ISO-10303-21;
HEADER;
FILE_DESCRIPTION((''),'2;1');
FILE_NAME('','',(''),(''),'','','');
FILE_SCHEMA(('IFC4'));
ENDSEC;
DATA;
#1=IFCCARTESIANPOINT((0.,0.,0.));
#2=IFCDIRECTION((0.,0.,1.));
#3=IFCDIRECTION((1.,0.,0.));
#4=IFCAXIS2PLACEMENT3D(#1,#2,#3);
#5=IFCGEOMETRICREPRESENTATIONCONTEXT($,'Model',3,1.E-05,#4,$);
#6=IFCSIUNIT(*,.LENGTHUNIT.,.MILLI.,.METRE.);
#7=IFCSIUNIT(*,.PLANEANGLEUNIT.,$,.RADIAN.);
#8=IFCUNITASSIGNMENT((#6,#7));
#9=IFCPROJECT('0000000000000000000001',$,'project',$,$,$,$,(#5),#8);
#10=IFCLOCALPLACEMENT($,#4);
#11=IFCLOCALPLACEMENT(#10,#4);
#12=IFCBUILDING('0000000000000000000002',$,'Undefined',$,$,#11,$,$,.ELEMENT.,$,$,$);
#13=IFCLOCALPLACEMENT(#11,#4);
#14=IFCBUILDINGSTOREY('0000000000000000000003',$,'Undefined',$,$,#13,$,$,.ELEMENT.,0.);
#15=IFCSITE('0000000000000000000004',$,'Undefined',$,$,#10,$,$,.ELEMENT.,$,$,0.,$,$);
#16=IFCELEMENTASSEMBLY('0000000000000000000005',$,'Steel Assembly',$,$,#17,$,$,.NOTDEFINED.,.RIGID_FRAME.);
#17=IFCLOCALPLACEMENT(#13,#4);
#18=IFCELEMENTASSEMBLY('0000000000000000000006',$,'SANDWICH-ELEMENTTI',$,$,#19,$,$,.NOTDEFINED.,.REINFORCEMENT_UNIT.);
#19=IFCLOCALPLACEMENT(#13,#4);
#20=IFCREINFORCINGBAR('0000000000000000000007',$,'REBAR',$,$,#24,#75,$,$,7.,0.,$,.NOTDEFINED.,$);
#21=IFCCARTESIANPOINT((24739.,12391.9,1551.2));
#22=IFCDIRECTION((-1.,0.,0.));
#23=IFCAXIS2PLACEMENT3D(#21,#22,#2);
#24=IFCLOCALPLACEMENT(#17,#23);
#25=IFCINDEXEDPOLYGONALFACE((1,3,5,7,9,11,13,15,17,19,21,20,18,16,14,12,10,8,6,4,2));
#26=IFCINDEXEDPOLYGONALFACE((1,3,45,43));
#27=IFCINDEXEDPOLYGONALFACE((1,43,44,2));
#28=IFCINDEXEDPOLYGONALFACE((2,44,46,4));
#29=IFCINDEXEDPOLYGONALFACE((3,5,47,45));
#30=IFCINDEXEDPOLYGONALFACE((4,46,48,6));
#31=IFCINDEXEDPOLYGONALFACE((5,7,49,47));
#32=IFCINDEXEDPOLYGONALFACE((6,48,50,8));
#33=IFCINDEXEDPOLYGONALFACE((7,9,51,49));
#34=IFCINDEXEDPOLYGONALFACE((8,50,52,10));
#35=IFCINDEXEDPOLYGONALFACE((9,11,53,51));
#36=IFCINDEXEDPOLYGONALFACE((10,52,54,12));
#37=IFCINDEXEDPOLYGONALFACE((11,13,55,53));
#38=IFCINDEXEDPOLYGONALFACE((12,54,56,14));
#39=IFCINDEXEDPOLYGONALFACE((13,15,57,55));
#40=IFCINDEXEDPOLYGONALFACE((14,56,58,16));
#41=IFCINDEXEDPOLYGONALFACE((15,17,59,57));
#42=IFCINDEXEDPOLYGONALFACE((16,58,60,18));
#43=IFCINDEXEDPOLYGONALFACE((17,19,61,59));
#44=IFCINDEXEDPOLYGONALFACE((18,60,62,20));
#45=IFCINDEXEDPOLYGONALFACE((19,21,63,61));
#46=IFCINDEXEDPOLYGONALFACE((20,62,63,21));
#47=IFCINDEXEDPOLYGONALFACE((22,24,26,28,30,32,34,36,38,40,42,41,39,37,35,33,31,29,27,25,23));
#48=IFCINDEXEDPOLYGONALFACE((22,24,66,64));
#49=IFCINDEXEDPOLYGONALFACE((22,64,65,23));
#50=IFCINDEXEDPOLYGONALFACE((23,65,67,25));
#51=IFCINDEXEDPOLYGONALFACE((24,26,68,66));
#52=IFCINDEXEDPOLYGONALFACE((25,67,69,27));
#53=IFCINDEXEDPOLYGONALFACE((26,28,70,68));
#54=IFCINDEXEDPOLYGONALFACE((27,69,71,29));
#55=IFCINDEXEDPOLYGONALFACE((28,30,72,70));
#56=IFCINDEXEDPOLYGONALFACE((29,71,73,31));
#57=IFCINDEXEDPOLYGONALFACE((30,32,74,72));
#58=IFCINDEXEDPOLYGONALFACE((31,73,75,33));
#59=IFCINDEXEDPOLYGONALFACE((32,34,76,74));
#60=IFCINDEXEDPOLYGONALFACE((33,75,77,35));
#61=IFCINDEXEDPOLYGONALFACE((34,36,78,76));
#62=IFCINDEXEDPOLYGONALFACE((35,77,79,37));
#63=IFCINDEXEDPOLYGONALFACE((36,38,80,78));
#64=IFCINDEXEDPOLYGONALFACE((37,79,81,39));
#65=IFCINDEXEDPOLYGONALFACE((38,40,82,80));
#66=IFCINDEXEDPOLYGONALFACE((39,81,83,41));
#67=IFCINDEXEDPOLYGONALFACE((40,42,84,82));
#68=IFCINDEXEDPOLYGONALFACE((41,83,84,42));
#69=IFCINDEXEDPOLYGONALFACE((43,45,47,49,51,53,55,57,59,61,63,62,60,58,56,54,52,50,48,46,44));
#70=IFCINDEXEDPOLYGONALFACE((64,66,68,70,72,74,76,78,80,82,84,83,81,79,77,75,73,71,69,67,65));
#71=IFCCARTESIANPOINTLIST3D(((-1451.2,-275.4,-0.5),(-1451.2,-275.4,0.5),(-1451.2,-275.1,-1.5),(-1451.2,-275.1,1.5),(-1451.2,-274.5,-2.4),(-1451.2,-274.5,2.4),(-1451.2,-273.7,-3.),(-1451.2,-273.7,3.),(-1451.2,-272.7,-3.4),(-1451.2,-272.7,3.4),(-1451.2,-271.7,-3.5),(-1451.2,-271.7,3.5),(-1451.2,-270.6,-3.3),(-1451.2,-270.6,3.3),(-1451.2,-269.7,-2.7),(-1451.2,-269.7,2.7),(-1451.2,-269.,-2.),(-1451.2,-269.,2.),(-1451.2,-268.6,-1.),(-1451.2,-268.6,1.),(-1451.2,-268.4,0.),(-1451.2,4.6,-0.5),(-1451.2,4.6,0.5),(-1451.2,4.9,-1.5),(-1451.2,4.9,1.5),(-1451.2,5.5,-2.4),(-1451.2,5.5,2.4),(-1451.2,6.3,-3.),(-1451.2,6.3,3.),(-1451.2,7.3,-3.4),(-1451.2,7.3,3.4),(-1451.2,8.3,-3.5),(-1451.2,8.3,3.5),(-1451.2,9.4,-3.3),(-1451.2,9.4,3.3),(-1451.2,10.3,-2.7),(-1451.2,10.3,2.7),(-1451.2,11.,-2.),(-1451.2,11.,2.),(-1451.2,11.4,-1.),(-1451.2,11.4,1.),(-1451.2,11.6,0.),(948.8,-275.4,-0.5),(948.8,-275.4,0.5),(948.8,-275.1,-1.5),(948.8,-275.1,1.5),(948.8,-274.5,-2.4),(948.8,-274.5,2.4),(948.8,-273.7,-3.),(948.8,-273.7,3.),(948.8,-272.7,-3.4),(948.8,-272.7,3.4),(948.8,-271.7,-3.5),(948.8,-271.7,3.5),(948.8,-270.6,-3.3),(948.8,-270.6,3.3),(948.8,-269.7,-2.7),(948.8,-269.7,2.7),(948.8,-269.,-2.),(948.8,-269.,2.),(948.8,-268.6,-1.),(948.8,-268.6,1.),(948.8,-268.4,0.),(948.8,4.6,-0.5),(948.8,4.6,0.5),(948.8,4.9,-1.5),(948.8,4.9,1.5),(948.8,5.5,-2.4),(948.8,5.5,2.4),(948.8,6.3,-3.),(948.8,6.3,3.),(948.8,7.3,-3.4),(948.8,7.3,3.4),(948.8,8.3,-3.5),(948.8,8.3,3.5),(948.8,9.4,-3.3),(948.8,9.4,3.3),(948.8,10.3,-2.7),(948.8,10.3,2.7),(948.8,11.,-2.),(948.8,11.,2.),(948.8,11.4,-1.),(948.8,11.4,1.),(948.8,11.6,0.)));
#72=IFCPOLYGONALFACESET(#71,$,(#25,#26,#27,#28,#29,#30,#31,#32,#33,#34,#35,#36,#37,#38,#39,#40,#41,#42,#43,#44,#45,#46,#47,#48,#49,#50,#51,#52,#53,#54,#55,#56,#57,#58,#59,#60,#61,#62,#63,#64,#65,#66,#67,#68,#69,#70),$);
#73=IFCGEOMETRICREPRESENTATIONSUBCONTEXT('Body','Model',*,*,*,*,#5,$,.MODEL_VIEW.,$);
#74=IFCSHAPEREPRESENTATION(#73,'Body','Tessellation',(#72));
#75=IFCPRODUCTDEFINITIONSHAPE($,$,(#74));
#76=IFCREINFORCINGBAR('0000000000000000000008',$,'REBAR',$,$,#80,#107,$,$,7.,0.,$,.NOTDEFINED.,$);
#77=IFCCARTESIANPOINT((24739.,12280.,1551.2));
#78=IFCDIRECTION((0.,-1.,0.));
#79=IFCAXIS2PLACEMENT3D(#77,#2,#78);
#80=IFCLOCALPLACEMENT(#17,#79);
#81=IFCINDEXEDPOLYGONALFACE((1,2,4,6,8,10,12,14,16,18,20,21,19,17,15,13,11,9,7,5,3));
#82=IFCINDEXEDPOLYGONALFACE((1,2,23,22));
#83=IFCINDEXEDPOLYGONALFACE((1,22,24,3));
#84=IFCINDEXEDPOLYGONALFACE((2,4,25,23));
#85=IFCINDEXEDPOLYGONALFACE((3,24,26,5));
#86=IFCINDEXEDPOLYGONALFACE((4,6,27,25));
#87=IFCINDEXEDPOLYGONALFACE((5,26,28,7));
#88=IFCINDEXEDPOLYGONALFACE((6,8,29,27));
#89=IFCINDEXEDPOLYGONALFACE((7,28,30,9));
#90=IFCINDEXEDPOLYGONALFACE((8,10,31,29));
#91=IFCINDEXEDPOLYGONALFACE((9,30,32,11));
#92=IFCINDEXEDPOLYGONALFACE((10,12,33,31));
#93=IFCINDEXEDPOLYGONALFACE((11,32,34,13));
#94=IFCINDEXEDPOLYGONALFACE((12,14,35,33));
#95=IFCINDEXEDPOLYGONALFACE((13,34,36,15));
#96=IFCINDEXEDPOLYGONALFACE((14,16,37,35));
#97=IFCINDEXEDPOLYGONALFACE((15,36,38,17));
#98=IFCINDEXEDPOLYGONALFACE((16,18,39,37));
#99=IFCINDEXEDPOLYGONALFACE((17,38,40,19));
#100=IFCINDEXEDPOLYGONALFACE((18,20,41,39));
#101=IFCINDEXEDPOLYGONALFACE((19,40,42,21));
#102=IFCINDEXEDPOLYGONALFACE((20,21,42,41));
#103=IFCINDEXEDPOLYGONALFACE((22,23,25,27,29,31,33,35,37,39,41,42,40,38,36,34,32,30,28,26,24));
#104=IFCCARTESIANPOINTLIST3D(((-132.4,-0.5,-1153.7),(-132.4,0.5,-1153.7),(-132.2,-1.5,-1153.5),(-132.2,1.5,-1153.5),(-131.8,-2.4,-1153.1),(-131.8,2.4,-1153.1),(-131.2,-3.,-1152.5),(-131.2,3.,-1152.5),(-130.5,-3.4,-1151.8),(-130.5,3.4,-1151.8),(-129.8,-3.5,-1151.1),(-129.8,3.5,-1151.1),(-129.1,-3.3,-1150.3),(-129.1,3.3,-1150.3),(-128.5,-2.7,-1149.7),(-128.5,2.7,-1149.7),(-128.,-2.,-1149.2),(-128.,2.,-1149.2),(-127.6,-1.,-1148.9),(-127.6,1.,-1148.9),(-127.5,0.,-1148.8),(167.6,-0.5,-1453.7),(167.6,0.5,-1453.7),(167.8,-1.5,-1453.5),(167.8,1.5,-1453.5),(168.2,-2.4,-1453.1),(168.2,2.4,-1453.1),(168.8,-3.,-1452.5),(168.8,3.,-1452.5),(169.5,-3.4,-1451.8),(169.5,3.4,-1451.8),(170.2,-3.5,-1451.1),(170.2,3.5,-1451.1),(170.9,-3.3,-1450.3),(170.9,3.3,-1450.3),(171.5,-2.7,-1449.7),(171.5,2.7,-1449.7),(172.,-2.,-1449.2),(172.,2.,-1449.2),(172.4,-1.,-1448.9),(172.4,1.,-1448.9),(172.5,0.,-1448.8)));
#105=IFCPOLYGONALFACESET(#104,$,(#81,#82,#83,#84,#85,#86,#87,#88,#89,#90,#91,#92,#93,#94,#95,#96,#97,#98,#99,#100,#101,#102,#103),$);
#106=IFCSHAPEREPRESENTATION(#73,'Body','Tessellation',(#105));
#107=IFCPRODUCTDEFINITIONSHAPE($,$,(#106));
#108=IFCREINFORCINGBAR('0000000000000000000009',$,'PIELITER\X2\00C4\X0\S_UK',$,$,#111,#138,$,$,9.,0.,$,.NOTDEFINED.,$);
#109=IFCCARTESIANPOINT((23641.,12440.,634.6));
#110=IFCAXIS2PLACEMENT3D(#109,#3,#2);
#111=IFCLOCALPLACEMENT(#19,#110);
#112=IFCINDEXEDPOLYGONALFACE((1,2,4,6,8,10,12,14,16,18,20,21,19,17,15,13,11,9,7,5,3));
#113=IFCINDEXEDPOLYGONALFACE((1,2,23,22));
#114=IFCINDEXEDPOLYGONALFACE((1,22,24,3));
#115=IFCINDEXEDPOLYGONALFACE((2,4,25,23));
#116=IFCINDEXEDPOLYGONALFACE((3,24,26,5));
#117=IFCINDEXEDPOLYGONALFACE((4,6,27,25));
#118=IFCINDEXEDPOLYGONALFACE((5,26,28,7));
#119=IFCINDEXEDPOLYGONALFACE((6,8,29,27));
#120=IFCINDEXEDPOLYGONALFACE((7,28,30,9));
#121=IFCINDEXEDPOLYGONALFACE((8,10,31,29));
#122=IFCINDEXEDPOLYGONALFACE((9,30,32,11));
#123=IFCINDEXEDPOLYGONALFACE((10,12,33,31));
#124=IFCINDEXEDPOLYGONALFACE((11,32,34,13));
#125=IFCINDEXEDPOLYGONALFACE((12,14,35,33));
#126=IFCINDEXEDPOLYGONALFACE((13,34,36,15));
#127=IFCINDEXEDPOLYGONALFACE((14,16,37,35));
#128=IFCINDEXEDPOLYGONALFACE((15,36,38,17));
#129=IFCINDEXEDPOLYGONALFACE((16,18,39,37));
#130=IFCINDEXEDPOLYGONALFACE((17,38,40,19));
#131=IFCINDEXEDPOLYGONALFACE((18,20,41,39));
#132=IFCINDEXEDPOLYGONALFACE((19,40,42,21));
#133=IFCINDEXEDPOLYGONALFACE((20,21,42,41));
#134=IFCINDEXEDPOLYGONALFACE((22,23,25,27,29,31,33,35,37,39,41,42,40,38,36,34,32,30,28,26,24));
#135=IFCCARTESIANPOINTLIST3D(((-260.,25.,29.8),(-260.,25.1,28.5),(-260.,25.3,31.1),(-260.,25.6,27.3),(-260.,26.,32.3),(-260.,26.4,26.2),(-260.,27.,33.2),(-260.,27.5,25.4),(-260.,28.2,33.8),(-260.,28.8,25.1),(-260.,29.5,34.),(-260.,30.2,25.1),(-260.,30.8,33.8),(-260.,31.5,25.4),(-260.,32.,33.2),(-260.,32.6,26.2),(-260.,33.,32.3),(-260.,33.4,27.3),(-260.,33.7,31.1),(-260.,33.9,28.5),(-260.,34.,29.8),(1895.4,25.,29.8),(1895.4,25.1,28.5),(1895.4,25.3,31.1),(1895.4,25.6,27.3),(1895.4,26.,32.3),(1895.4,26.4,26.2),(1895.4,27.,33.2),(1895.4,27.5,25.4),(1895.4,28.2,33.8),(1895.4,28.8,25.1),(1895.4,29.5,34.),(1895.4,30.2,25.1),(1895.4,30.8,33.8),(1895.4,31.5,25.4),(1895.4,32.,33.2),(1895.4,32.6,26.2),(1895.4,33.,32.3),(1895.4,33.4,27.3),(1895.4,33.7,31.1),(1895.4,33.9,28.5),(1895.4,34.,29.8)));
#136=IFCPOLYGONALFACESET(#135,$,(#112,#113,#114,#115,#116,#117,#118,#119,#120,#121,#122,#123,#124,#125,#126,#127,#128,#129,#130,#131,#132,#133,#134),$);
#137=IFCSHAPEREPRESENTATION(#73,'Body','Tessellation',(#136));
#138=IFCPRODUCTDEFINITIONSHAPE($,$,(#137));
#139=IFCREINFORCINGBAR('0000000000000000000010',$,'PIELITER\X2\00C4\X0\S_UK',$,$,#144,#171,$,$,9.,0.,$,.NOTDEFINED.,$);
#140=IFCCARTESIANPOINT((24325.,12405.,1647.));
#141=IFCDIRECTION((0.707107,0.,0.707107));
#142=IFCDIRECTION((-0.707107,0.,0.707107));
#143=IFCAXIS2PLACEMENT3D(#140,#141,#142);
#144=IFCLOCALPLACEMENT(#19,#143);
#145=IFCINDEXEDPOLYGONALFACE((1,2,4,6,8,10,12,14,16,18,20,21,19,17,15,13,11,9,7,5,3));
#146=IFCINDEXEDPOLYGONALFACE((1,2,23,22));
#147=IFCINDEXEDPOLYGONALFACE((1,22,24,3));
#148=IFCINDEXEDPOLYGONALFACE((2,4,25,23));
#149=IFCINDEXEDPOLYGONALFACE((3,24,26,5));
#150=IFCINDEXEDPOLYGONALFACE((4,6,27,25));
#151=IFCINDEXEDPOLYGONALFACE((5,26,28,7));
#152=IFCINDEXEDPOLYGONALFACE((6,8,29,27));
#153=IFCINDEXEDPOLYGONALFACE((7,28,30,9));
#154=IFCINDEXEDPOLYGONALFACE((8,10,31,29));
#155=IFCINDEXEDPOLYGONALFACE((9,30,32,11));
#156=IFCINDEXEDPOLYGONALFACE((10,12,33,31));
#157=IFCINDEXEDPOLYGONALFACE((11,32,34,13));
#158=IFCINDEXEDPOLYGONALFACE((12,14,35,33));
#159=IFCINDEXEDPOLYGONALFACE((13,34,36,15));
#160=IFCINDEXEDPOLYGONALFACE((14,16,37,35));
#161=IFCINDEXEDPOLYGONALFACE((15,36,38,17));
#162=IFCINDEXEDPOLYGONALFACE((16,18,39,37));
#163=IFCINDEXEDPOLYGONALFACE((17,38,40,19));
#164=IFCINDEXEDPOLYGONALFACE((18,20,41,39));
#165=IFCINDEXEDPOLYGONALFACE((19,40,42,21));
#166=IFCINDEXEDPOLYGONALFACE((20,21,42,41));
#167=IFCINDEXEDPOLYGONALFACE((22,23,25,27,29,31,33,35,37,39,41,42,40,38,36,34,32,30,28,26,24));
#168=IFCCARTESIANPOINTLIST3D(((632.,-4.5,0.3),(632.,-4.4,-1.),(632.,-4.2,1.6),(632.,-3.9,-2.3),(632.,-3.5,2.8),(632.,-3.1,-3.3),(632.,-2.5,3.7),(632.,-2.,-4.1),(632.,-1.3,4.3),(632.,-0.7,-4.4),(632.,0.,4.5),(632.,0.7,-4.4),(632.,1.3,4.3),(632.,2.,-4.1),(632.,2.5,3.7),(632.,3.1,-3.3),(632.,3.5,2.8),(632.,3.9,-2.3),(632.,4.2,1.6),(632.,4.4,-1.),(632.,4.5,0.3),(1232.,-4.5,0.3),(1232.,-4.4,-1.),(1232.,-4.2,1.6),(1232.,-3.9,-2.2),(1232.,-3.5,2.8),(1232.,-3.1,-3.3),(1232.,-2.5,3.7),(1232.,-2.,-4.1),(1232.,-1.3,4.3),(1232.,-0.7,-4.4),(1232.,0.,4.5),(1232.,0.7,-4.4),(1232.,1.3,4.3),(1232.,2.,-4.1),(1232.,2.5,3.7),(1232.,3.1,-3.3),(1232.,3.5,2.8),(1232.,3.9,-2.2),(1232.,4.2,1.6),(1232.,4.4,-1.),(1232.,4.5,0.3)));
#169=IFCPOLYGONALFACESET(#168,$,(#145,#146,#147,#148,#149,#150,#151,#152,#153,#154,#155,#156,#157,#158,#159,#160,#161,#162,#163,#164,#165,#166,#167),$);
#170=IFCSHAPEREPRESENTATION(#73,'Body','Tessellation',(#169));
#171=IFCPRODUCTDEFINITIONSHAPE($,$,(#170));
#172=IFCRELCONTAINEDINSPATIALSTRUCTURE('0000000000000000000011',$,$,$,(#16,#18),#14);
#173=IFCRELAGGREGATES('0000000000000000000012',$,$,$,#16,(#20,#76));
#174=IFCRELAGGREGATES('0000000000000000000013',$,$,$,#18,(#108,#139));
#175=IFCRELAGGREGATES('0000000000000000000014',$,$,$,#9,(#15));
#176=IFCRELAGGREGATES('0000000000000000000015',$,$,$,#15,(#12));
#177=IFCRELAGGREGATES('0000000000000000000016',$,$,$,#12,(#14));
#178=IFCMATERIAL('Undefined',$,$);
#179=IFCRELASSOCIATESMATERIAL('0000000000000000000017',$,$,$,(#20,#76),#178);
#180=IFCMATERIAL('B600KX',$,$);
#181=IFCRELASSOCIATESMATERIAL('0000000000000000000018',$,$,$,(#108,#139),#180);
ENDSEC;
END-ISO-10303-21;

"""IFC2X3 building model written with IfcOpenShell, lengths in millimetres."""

from ifc_helpers import new_model, entity, si_unit, frame, origin_with_axes, place, context, subcontext, project, spatial, source, transform, mapped, material, element, aggregate, save


model = new_model("IFC2X3")

# Units and contexts
model_context = context("Model", 3, precision=1e-05, world=origin_with_axes())
body_context = subcontext(model_context, "Body", "Model", "MODEL_VIEW")
ifc_project = project(units=[si_unit("LENGTHUNIT", "METRE", prefix="MILLI"), si_unit("PLANEANGLEUNIT", "RADIAN")], contexts=[model_context])

# Site, building, storey
site_placement = place(None, origin_with_axes())
site = spatial("IfcSite", under=ifc_project, at=site_placement, Name="Undefined", CompositionType="ELEMENT", RefElevation=0.0)
building_placement = place(site_placement, origin_with_axes())
building = spatial("IfcBuilding", under=site, at=building_placement, Name="Undefined", CompositionType="ELEMENT")
storey_placement = place(building_placement, origin_with_axes())
storey = spatial("IfcBuildingStorey", under=building, at=storey_placement, Name="Undefined", CompositionType="ELEMENT", Elevation=0.0)

# Element assembly
assembly_1_placement = place(storey_placement, origin_with_axes())
assembly_1 = element("IfcElementAssembly", 1, at=assembly_1_placement, inside=storey, Name="Steel Assembly", AssemblyPlace="NOTDEFINED", PredefinedType="RIGID_FRAME")

# Element assembly
assembly_2_placement = place(storey_placement, origin_with_axes())
assembly_2 = element("IfcElementAssembly", 2, at=assembly_2_placement, inside=storey, Name="SANDWICH-ELEMENTTI", AssemblyPlace="NOTDEFINED", PredefinedType="REINFORCEMENT_UNIT")

# Shared definitions
ifc_material_1 = material(Name="Undefined")

# Reinforcing bars
shared_shape_1 = source(origin_with_axes(), body_context, "Body", "AdvancedSweptSolid", [
    entity("IfcSweptDiskSolid", entity("IfcTrimmedCurve", entity("IfcLine", entity("IfcCartesianPoint", [0.0, 0.0, 0.0]), entity("IfcVector", entity("IfcDirection", [1.0, 0.000003, 0.0]), 1.0)), [entity("IfcParameterValue", 0.0)], [entity("IfcParameterValue", 2400.0)], True, "PARAMETER"), 3.5, None, 0.0, 2400.0),
])
shared_shape_2 = source(origin_with_axes(), body_context, "Body", "AdvancedSweptSolid", [
    entity("IfcSweptDiskSolid", entity("IfcTrimmedCurve", entity("IfcLine", entity("IfcCartesianPoint", [0.0, 0.0, 0.0]), entity("IfcVector", entity("IfcDirection", [1.0, 0.000003, 0.0]), 1.0)), [entity("IfcParameterValue", 0.0)], [entity("IfcParameterValue", 2400.0)], True, "PARAMETER"), 3.5, None, 0.0, 2400.0),
])
reinforcing_bar_1_placement = place(assembly_1_placement, frame((24739.0, 12391.9, 1551.2), z_axis=(-1.0, 0.0, 0.0), x_axis=(0.0, 0.0, 1.0)))
reinforcing_bar_1 = element("IfcReinforcingBar", 3, at=reinforcing_bar_1_placement, material=ifc_material_1, Name="REBAR", BarRole="NOTDEFINED", CrossSectionArea=0.0, NominalDiameter=7.0, context=body_context, shape_type="MappedRepresentation", body=[
    mapped(shared_shape_1, transform((-1451.2, -271.9, 0.0))),
    mapped(shared_shape_2, transform((-1451.2, 8.1, 0.0))),
])
shared_shape_3 = source(origin_with_axes(), body_context, "Body", "AdvancedSweptSolid", [
    entity("IfcSweptDiskSolid", entity("IfcTrimmedCurve", entity("IfcLine", entity("IfcCartesianPoint", [0.0, 0.0, 0.0]), entity("IfcVector", entity("IfcDirection", [0.707107, 0.0, -0.707107]), 1.0)), [entity("IfcParameterValue", 0.0)], [entity("IfcParameterValue", 424.264069)], True, "PARAMETER"), 3.5, None, 0.0, 424.3),
])
reinforcing_bar_2_placement = place(assembly_1_placement, frame((24739.0, 12280.0, 1551.2), z_axis=(0.0, 0.0, 1.0), x_axis=(0.0, -1.0, 0.0)))
reinforcing_bar_2 = element("IfcReinforcingBar", 4, at=reinforcing_bar_2_placement, material=ifc_material_1, Name="REBAR", BarRole="NOTDEFINED", CrossSectionArea=0.0, NominalDiameter=7.0, context=body_context, shape_type="MappedRepresentation", body=[
    mapped(shared_shape_3, transform((-130.0, 0.0, -1151.2))),
])
aggregate(assembly_1, [reinforcing_bar_1, reinforcing_bar_2])

# Reinforcing bars
ifc_material_2 = material(Name="B600KX")
shared_shape_4 = source(origin_with_axes(), body_context, "Body", "AdvancedSweptSolid", [
    entity("IfcSweptDiskSolid", entity("IfcTrimmedCurve", entity("IfcLine", entity("IfcCartesianPoint", [0.0, 0.0, 0.0]), entity("IfcVector", entity("IfcDirection", [1.0, 0.0, 0.0]), 1.0)), [entity("IfcParameterValue", 0.0)], [entity("IfcParameterValue", 2155.391)], True, "PARAMETER"), 4.5, None, 0.0, 2155.4),
])
reinforcing_bar_3_placement = place(assembly_2_placement, frame((23641.0, 12440.0, 634.6), z_axis=(1.0, 0.0, 0.0), x_axis=(0.0, 0.0, 1.0)))
reinforcing_bar_3 = element("IfcReinforcingBar", 5, at=reinforcing_bar_3_placement, material=ifc_material_2, Name="PIELITERÄS_UK", BarRole="NOTDEFINED", CrossSectionArea=0.0, NominalDiameter=9.0, context=body_context, shape_type="MappedRepresentation", body=[
    mapped(shared_shape_4, transform((-260.0, 29.5, 29.5))),
])
shared_shape_5 = source(origin_with_axes(), body_context, "Body", "AdvancedSweptSolid", [
    entity("IfcSweptDiskSolid", entity("IfcTrimmedCurve", entity("IfcLine", entity("IfcCartesianPoint", [0.0, 0.0, 0.0]), entity("IfcVector", entity("IfcDirection", [1.0, 0.0, 0.0]), 1.0)), [entity("IfcParameterValue", 0.0)], [entity("IfcParameterValue", 600.0)], True, "PARAMETER"), 4.5, None, 0.0, 600.0),
])
reinforcing_bar_4_placement = place(assembly_2_placement, frame((24325.0, 12405.0, 1647.0), z_axis=(0.707107, 0.0, 0.707107), x_axis=(-0.707107, 0.0, 0.707107)))
reinforcing_bar_4 = element("IfcReinforcingBar", 6, at=reinforcing_bar_4_placement, material=ifc_material_2, Name="PIELITERÄS_UK", BarRole="NOTDEFINED", CrossSectionArea=0.0, NominalDiameter=9.0, context=body_context, shape_type="MappedRepresentation", body=[
    mapped(shared_shape_5, transform((632.0, 0.0, 0.0))),
])
aggregate(assembly_2, [reinforcing_bar_3, reinforcing_bar_4])

save(model, "model.ifc")
